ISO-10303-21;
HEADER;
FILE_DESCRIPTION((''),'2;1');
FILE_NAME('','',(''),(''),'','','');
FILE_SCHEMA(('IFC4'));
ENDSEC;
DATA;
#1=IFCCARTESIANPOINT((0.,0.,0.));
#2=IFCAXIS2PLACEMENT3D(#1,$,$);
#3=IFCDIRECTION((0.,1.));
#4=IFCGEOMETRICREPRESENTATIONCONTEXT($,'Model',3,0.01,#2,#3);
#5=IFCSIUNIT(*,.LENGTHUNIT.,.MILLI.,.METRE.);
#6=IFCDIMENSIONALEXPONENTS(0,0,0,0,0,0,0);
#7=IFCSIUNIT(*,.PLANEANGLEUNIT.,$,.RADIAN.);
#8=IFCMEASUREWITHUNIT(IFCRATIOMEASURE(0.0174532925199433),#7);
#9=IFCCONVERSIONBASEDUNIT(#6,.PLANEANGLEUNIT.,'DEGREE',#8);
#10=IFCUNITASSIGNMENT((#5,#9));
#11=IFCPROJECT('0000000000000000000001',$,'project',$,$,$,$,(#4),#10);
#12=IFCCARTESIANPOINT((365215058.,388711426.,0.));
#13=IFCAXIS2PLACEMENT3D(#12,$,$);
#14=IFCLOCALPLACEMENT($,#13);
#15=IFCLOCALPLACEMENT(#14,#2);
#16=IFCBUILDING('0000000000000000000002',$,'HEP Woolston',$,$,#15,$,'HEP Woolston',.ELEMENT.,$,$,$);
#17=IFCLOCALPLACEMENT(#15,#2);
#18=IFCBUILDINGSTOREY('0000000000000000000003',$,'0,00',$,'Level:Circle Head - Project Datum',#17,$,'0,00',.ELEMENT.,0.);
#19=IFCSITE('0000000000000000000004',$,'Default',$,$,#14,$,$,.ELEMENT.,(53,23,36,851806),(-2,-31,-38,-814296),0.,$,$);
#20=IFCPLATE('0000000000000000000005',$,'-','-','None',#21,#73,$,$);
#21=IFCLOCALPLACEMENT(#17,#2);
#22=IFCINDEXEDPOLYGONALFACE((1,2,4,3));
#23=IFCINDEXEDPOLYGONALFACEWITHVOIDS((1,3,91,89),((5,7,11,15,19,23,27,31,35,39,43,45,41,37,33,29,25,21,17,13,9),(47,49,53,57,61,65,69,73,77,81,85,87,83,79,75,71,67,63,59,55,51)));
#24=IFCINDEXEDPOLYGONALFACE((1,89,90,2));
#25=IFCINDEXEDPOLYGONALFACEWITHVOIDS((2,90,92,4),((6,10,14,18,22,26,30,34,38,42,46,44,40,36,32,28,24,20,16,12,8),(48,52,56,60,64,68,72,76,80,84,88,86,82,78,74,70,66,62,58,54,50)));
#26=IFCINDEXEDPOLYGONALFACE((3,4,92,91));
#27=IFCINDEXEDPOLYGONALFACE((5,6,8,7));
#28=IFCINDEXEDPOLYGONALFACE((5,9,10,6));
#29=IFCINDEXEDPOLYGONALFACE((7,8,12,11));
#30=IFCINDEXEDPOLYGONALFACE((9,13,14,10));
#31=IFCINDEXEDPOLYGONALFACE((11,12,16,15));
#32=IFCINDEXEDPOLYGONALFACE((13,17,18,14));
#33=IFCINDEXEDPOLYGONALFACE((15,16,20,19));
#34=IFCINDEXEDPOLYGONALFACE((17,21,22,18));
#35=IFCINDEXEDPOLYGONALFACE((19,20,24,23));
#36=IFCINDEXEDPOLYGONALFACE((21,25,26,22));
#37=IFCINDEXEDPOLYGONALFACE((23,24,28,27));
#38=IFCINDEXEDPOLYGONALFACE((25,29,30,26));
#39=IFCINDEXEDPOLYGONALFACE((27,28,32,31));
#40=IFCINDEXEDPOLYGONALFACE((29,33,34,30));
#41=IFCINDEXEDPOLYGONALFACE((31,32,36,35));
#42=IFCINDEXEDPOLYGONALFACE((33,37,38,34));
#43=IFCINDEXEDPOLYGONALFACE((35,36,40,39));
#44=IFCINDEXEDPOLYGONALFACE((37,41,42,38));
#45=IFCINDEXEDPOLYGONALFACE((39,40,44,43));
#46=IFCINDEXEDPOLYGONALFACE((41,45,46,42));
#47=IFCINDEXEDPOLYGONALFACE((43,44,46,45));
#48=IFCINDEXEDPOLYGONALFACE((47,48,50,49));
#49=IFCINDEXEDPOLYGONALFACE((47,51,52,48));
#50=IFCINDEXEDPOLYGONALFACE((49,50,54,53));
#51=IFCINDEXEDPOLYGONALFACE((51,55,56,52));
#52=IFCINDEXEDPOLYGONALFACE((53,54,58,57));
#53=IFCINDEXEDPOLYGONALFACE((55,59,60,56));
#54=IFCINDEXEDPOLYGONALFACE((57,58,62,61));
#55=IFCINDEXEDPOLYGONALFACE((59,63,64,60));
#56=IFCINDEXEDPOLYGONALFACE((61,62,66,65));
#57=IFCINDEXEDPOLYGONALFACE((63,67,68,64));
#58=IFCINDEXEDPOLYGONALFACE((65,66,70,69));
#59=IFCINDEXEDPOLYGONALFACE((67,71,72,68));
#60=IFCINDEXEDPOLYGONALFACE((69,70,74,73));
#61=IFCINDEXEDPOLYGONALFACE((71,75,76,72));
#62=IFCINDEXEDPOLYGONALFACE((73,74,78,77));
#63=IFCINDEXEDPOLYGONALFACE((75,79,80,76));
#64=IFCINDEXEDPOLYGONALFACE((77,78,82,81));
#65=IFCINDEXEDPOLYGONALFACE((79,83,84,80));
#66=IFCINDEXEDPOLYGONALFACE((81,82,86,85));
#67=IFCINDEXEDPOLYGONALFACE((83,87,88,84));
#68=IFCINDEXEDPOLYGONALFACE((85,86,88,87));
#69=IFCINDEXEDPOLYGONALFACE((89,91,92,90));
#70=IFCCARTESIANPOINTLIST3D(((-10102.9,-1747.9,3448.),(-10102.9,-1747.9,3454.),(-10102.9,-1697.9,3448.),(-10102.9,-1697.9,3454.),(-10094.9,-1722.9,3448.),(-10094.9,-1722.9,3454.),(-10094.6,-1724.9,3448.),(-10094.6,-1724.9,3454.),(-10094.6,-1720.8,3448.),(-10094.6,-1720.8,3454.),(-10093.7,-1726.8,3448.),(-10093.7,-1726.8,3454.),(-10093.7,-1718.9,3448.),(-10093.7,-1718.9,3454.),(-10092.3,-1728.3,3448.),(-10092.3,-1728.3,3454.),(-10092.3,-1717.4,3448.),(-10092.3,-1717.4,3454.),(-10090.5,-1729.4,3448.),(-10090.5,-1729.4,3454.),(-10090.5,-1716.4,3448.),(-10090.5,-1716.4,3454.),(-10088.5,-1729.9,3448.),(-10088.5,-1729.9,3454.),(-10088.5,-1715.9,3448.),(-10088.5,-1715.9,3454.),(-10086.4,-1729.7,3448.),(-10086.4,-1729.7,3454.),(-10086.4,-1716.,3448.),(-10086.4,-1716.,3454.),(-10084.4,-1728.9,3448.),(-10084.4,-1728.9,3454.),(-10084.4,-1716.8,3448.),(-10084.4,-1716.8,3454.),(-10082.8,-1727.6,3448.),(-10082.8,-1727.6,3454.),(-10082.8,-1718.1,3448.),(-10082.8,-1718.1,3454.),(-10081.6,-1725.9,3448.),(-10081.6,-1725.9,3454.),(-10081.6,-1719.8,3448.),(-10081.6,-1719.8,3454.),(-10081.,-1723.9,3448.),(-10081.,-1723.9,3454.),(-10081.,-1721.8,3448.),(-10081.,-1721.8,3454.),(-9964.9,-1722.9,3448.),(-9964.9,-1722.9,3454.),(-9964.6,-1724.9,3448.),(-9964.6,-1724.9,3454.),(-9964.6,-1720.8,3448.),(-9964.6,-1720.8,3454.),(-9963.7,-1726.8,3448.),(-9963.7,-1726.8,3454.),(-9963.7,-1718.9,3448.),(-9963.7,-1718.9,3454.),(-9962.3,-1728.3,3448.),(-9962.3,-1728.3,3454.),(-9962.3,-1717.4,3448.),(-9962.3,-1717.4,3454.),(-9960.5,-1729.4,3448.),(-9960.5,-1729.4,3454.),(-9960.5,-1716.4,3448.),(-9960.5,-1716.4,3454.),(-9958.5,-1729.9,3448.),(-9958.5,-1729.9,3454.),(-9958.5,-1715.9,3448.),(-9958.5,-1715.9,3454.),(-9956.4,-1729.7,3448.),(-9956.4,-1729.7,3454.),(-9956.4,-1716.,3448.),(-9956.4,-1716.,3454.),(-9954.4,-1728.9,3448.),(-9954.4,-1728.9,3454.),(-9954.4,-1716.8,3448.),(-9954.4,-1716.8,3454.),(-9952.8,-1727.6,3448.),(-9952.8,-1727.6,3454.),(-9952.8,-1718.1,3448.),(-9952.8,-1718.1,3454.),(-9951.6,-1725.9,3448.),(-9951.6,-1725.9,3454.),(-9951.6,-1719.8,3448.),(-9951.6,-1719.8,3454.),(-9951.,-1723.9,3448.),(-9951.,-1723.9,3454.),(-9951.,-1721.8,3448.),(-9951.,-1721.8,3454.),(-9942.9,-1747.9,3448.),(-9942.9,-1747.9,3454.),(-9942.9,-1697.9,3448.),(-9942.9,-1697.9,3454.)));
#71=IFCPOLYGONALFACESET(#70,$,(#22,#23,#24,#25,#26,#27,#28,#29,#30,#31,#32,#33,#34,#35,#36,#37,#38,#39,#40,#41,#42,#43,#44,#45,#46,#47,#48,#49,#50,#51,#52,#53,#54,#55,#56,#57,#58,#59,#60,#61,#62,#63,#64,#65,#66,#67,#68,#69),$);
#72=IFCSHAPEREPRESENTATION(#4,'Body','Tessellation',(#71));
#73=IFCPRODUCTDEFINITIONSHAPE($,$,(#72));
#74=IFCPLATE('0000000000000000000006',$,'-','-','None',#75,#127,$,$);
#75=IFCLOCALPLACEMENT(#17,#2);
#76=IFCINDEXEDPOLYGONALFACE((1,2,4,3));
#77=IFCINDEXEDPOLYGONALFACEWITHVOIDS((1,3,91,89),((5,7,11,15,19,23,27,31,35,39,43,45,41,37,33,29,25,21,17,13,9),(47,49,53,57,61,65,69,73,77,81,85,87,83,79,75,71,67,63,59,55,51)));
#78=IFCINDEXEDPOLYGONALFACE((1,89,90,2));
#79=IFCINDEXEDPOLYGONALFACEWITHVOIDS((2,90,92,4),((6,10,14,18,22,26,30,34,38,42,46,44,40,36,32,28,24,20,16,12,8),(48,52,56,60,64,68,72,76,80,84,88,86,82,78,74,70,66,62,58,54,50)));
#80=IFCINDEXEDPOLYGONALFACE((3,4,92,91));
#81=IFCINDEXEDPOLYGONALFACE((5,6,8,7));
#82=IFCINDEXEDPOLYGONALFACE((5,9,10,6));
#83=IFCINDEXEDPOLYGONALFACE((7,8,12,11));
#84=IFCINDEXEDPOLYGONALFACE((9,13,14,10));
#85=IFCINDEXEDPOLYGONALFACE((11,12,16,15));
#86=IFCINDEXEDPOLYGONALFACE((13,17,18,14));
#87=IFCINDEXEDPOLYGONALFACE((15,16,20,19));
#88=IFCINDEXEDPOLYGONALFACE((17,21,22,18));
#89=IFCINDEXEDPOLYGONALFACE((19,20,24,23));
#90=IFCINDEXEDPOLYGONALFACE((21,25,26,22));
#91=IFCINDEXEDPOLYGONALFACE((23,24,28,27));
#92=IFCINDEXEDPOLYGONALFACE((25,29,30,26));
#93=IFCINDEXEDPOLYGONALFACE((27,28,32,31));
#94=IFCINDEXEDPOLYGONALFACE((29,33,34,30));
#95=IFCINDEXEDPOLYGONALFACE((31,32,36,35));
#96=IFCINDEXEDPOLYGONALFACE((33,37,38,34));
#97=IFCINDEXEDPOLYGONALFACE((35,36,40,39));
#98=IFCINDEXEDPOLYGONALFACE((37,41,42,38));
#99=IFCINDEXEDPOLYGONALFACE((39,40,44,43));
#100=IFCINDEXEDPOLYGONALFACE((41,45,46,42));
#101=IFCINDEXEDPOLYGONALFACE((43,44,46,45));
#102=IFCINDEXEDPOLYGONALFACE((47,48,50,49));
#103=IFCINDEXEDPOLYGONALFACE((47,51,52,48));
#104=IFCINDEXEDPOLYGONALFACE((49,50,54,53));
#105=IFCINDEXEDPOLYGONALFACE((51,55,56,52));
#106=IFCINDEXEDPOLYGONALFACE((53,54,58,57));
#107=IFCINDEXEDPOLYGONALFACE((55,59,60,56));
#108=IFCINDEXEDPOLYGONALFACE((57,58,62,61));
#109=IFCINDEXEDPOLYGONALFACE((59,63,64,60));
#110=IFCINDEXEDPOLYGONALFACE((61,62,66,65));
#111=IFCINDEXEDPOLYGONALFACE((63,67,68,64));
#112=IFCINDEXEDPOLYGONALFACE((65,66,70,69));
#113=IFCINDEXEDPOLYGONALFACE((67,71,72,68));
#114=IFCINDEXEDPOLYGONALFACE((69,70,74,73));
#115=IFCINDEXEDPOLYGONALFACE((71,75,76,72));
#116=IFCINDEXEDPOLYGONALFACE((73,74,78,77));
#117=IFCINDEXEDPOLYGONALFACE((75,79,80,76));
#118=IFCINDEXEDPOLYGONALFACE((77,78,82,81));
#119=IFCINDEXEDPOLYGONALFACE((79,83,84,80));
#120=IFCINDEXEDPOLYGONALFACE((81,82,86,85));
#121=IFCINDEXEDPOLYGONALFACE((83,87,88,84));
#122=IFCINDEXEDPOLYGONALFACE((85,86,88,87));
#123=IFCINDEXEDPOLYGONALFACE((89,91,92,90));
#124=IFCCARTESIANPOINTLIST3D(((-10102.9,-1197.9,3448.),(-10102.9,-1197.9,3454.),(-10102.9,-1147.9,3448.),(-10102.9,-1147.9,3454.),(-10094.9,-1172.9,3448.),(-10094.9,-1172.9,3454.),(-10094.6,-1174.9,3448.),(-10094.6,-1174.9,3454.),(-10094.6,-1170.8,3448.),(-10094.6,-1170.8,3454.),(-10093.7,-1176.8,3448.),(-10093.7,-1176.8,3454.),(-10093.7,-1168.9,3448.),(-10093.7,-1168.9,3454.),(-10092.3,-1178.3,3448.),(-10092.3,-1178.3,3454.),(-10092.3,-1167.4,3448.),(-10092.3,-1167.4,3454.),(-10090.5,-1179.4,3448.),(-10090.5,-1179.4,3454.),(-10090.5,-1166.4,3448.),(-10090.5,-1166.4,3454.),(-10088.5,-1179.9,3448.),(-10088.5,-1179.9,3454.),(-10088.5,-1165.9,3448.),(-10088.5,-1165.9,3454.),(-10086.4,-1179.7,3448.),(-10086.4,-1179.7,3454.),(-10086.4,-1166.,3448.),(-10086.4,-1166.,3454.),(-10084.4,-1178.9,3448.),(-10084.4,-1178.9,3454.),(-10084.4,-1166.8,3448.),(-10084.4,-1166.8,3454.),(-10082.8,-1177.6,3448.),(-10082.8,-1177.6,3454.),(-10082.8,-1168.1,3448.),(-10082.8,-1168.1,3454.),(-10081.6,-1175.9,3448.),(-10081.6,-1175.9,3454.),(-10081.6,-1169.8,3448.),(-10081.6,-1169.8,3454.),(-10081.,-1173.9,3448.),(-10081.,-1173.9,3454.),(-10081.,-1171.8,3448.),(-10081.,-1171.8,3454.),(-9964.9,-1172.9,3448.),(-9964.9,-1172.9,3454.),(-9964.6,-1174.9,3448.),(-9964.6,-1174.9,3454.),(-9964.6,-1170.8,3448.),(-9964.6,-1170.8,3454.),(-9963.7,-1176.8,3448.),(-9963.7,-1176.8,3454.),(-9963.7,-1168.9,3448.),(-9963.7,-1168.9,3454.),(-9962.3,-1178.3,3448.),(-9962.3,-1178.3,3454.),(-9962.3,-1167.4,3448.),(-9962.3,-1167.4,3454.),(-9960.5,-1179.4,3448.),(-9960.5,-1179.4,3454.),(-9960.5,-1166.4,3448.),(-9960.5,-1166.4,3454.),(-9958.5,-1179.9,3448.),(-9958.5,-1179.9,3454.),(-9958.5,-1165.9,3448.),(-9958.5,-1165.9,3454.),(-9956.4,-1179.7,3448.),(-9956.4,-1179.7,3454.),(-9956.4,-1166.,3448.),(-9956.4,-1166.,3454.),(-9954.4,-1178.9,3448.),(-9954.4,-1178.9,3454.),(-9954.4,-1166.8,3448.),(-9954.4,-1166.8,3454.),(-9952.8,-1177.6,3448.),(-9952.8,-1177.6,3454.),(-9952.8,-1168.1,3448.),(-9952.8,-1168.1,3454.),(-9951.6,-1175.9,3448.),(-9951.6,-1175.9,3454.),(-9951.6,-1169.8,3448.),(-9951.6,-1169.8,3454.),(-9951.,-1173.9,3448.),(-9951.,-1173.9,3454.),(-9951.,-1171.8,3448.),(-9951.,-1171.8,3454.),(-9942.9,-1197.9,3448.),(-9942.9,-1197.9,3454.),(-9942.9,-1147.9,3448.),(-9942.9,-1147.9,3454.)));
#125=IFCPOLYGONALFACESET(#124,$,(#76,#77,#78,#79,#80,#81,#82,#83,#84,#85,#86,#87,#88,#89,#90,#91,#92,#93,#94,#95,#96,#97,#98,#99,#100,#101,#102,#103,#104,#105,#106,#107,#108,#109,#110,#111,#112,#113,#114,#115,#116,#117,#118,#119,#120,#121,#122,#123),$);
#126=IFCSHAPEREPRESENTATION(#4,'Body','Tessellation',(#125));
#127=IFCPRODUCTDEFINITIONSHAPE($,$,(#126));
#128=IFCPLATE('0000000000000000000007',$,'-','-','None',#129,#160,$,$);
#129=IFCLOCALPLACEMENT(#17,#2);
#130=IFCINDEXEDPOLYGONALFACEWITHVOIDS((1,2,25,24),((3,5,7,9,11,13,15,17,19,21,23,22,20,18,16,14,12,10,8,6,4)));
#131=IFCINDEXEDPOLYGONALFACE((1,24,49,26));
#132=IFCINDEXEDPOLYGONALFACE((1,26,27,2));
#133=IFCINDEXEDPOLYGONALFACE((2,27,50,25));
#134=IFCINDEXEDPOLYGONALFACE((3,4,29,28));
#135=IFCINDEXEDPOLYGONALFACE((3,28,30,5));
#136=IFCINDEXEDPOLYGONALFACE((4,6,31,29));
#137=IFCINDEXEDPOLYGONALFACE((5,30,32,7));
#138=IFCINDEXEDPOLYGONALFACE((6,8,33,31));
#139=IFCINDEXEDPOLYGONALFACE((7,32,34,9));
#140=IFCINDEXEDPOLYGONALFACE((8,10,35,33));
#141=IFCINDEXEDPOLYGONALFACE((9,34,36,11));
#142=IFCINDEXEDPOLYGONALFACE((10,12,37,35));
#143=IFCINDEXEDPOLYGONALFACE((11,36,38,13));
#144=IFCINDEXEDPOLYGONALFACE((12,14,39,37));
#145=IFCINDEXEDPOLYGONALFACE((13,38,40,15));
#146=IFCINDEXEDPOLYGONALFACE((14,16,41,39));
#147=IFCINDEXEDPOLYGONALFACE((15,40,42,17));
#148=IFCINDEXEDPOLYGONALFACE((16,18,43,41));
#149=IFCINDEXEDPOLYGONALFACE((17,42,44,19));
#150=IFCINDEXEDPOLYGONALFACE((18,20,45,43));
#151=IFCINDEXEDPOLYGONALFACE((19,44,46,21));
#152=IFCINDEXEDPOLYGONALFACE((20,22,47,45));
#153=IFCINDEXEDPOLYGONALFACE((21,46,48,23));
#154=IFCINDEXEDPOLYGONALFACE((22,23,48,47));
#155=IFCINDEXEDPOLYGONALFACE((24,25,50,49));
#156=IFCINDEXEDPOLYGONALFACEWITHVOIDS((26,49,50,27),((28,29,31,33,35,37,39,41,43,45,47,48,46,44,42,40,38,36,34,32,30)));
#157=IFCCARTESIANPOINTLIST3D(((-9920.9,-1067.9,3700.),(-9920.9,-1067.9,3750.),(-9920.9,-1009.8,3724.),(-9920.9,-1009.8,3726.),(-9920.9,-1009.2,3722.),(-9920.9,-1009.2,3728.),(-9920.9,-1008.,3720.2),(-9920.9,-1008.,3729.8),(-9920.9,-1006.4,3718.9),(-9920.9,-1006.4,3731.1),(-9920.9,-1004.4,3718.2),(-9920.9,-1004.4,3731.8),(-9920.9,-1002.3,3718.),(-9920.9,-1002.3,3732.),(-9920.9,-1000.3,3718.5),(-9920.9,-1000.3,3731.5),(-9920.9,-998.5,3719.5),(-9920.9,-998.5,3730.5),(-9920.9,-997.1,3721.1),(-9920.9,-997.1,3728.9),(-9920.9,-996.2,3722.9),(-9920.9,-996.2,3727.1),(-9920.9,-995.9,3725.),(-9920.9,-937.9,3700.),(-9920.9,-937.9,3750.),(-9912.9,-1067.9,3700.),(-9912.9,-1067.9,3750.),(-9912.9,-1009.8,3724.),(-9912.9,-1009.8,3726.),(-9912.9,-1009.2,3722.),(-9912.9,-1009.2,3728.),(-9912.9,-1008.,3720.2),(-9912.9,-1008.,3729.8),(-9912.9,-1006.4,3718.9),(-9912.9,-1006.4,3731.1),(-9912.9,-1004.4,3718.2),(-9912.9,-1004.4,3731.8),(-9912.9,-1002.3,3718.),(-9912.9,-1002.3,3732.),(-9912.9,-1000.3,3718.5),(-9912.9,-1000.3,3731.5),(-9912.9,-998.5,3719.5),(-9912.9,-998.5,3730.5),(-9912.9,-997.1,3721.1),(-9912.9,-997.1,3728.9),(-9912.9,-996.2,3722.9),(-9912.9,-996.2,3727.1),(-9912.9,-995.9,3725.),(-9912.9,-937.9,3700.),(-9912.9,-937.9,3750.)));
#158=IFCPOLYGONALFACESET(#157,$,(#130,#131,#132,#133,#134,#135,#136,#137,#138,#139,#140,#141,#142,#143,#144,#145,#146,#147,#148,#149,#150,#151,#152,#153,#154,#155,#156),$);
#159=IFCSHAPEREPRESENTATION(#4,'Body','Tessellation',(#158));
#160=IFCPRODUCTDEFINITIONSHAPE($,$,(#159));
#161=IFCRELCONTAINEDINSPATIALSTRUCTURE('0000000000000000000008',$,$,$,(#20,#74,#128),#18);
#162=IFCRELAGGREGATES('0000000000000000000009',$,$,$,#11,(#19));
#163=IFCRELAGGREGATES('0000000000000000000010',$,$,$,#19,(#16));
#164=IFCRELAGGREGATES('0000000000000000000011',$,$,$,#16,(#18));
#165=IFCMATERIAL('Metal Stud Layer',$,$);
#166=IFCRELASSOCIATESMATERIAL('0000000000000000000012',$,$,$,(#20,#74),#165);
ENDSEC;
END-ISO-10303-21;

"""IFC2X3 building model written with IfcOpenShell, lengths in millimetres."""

from ifc_helpers import new_model, entity, si_unit, converted_unit, direction, frame, frame_2d, origin, origin_with_axes, origin_2d_with_axis, place, context, project, spatial, polyline, circle, outline, extrude, material, element, save


model = new_model("IFC2X3")

# Units and contexts
model_context = context("Model", 3, precision=0.01, world=origin(), true_north=direction((0.0, 1.0)))
ifc_project = project(units=[si_unit("LENGTHUNIT", "METRE", prefix="MILLI"), converted_unit("PLANEANGLEUNIT", "DEGREE", entity("IfcRatioMeasure", 0.0174532925199433), si_unit("PLANEANGLEUNIT", "RADIAN"), dimensions=[0, 0, 0, 0, 0, 0, 0])], contexts=[model_context])

# Site, building, storey
site_placement = place(None, frame((365215058.0, 388711426.0, 0.0)))
site = spatial("IfcSite", under=ifc_project, at=site_placement, Name="Default", CompositionType="ELEMENT", RefLatitude=(53, 23, 36, 851806), RefLongitude=(-2, -31, -38, -814296), RefElevation=0.0)
building_placement = place(site_placement, origin())
building = spatial("IfcBuilding", under=site, at=building_placement, Name="HEP Woolston", LongName="HEP Woolston", CompositionType="ELEMENT")
storey_placement = place(building_placement, origin())
storey = spatial("IfcBuildingStorey", under=building, at=storey_placement, Name="0,00", ObjectType="Level:Circle Head - Project Datum", LongName="0,00", CompositionType="ELEMENT", Elevation=0.0)

# Plates, openings
ifc_material = material(Name="Metal Stud Layer")
plate_1_placement = place(storey_placement, frame((-9942.9, -1747.9, 3454.0), z_axis=(0.0, 0.0, -1.0), x_axis=(-1.0, 0.0, 0.0)))
plate_1 = element("IfcPlate", 1, at=plate_1_placement, inside=storey, material=ifc_material, Name="-", Description="-", ObjectType="None", context=model_context, shape_type="SweptSolid", body=[
    extrude(outline(polyline([(160.0, 0.0), (160.0, 50.0), (0.0, 50.0), (0.0, 0.0), (160.0, 0.0)])), origin_with_axes(), (0.0, 0.0, 1.0), 6.0),
])
opening_1_placement = place(plate_1_placement, frame((80.0, 25.0, 6.5), z_axis=(0.0, 0.0, -1.0), x_axis=(1.0, 0.0, 0.0)))
element("IfcOpeningElement", 2, at=opening_1_placement, cuts=plate_1, ObjectType="Opening", context=model_context, shape_type="SweptSolid", body=[
    extrude(circle(Radius=7.0, at=frame_2d((65.0, 0.0), x_axis=(1.0, 0.0))), origin(), (0.0, 0.0, 1.0), 7.0),
])
opening_2_placement = place(plate_1_placement, frame((80.0, 25.0, 6.5), z_axis=(0.0, 0.0, -1.0), x_axis=(1.0, 0.0, 0.0)))
element("IfcOpeningElement", 3, at=opening_2_placement, cuts=plate_1, ObjectType="Opening", context=model_context, shape_type="SweptSolid", body=[
    extrude(circle(Radius=7.0, at=frame_2d((-65.0, 0.0), x_axis=(1.0, 0.0))), origin(), (0.0, 0.0, 1.0), 7.0),
])
plate_2_placement = place(storey_placement, frame((-9942.9, -1197.9, 3454.0), z_axis=(0.0, 0.0, -1.0), x_axis=(-1.0, 0.0, 0.0)))
plate_2 = element("IfcPlate", 4, at=plate_2_placement, inside=storey, material=ifc_material, Name="-", Description="-", ObjectType="None", context=model_context, shape_type="SweptSolid", body=[
    extrude(outline(polyline([(160.0, 0.0), (160.0, 50.0), (0.0, 50.0), (0.0, 0.0), (160.0, 0.0)])), origin_with_axes(), (0.0, 0.0, 1.0), 6.0),
])
opening_3_placement = place(plate_2_placement, frame((80.0, 25.0, 6.5), z_axis=(0.0, 0.0, -1.0), x_axis=(1.0, 0.0, 0.0)))
element("IfcOpeningElement", 5, at=opening_3_placement, cuts=plate_2, ObjectType="Opening", context=model_context, shape_type="SweptSolid", body=[
    extrude(circle(Radius=7.0, at=frame_2d((65.0, 0.0), x_axis=(1.0, 0.0))), origin(), (0.0, 0.0, 1.0), 7.0),
])
opening_4_placement = place(plate_2_placement, frame((80.0, 25.0, 6.5), z_axis=(0.0, 0.0, -1.0), x_axis=(1.0, 0.0, 0.0)))
element("IfcOpeningElement", 6, at=opening_4_placement, cuts=plate_2, ObjectType="Opening", context=model_context, shape_type="SweptSolid", body=[
    extrude(circle(Radius=7.0, at=frame_2d((-65.0, 0.0), x_axis=(1.0, 0.0))), origin(), (0.0, 0.0, 1.0), 7.0),
])

# Plate, opening
plate_3_placement = place(storey_placement, frame((-9920.9, -1067.9, 3750.0), z_axis=(1.0, 0.0, 0.0), x_axis=(0.0, 1.0, 0.0)))
plate_3 = element("IfcPlate", 7, at=plate_3_placement, inside=storey, Name="-", Description="-", ObjectType="None", context=model_context, shape_type="SweptSolid", body=[
    extrude(outline(polyline([(0.0, -50.0), (130.0, -50.0), (130.0, 0.0), (0.0, 0.0), (0.0, -50.0)])), origin_with_axes(), (0.0, 0.0, 1.0), 8.0),
])
opening_5_placement = place(plate_3_placement, frame((65.0, -25.0, 8.5), z_axis=(0.0, 0.0, -1.0), x_axis=(1.0, 0.0, 0.0)))
element("IfcOpeningElement", 8, at=opening_5_placement, cuts=plate_3, ObjectType="Opening", context=model_context, shape_type="SweptSolid", body=[
    extrude(circle(Radius=7.0, at=origin_2d_with_axis()), origin(), (0.0, 0.0, 1.0), 9.0),
])

save(model, "model.ifc")
